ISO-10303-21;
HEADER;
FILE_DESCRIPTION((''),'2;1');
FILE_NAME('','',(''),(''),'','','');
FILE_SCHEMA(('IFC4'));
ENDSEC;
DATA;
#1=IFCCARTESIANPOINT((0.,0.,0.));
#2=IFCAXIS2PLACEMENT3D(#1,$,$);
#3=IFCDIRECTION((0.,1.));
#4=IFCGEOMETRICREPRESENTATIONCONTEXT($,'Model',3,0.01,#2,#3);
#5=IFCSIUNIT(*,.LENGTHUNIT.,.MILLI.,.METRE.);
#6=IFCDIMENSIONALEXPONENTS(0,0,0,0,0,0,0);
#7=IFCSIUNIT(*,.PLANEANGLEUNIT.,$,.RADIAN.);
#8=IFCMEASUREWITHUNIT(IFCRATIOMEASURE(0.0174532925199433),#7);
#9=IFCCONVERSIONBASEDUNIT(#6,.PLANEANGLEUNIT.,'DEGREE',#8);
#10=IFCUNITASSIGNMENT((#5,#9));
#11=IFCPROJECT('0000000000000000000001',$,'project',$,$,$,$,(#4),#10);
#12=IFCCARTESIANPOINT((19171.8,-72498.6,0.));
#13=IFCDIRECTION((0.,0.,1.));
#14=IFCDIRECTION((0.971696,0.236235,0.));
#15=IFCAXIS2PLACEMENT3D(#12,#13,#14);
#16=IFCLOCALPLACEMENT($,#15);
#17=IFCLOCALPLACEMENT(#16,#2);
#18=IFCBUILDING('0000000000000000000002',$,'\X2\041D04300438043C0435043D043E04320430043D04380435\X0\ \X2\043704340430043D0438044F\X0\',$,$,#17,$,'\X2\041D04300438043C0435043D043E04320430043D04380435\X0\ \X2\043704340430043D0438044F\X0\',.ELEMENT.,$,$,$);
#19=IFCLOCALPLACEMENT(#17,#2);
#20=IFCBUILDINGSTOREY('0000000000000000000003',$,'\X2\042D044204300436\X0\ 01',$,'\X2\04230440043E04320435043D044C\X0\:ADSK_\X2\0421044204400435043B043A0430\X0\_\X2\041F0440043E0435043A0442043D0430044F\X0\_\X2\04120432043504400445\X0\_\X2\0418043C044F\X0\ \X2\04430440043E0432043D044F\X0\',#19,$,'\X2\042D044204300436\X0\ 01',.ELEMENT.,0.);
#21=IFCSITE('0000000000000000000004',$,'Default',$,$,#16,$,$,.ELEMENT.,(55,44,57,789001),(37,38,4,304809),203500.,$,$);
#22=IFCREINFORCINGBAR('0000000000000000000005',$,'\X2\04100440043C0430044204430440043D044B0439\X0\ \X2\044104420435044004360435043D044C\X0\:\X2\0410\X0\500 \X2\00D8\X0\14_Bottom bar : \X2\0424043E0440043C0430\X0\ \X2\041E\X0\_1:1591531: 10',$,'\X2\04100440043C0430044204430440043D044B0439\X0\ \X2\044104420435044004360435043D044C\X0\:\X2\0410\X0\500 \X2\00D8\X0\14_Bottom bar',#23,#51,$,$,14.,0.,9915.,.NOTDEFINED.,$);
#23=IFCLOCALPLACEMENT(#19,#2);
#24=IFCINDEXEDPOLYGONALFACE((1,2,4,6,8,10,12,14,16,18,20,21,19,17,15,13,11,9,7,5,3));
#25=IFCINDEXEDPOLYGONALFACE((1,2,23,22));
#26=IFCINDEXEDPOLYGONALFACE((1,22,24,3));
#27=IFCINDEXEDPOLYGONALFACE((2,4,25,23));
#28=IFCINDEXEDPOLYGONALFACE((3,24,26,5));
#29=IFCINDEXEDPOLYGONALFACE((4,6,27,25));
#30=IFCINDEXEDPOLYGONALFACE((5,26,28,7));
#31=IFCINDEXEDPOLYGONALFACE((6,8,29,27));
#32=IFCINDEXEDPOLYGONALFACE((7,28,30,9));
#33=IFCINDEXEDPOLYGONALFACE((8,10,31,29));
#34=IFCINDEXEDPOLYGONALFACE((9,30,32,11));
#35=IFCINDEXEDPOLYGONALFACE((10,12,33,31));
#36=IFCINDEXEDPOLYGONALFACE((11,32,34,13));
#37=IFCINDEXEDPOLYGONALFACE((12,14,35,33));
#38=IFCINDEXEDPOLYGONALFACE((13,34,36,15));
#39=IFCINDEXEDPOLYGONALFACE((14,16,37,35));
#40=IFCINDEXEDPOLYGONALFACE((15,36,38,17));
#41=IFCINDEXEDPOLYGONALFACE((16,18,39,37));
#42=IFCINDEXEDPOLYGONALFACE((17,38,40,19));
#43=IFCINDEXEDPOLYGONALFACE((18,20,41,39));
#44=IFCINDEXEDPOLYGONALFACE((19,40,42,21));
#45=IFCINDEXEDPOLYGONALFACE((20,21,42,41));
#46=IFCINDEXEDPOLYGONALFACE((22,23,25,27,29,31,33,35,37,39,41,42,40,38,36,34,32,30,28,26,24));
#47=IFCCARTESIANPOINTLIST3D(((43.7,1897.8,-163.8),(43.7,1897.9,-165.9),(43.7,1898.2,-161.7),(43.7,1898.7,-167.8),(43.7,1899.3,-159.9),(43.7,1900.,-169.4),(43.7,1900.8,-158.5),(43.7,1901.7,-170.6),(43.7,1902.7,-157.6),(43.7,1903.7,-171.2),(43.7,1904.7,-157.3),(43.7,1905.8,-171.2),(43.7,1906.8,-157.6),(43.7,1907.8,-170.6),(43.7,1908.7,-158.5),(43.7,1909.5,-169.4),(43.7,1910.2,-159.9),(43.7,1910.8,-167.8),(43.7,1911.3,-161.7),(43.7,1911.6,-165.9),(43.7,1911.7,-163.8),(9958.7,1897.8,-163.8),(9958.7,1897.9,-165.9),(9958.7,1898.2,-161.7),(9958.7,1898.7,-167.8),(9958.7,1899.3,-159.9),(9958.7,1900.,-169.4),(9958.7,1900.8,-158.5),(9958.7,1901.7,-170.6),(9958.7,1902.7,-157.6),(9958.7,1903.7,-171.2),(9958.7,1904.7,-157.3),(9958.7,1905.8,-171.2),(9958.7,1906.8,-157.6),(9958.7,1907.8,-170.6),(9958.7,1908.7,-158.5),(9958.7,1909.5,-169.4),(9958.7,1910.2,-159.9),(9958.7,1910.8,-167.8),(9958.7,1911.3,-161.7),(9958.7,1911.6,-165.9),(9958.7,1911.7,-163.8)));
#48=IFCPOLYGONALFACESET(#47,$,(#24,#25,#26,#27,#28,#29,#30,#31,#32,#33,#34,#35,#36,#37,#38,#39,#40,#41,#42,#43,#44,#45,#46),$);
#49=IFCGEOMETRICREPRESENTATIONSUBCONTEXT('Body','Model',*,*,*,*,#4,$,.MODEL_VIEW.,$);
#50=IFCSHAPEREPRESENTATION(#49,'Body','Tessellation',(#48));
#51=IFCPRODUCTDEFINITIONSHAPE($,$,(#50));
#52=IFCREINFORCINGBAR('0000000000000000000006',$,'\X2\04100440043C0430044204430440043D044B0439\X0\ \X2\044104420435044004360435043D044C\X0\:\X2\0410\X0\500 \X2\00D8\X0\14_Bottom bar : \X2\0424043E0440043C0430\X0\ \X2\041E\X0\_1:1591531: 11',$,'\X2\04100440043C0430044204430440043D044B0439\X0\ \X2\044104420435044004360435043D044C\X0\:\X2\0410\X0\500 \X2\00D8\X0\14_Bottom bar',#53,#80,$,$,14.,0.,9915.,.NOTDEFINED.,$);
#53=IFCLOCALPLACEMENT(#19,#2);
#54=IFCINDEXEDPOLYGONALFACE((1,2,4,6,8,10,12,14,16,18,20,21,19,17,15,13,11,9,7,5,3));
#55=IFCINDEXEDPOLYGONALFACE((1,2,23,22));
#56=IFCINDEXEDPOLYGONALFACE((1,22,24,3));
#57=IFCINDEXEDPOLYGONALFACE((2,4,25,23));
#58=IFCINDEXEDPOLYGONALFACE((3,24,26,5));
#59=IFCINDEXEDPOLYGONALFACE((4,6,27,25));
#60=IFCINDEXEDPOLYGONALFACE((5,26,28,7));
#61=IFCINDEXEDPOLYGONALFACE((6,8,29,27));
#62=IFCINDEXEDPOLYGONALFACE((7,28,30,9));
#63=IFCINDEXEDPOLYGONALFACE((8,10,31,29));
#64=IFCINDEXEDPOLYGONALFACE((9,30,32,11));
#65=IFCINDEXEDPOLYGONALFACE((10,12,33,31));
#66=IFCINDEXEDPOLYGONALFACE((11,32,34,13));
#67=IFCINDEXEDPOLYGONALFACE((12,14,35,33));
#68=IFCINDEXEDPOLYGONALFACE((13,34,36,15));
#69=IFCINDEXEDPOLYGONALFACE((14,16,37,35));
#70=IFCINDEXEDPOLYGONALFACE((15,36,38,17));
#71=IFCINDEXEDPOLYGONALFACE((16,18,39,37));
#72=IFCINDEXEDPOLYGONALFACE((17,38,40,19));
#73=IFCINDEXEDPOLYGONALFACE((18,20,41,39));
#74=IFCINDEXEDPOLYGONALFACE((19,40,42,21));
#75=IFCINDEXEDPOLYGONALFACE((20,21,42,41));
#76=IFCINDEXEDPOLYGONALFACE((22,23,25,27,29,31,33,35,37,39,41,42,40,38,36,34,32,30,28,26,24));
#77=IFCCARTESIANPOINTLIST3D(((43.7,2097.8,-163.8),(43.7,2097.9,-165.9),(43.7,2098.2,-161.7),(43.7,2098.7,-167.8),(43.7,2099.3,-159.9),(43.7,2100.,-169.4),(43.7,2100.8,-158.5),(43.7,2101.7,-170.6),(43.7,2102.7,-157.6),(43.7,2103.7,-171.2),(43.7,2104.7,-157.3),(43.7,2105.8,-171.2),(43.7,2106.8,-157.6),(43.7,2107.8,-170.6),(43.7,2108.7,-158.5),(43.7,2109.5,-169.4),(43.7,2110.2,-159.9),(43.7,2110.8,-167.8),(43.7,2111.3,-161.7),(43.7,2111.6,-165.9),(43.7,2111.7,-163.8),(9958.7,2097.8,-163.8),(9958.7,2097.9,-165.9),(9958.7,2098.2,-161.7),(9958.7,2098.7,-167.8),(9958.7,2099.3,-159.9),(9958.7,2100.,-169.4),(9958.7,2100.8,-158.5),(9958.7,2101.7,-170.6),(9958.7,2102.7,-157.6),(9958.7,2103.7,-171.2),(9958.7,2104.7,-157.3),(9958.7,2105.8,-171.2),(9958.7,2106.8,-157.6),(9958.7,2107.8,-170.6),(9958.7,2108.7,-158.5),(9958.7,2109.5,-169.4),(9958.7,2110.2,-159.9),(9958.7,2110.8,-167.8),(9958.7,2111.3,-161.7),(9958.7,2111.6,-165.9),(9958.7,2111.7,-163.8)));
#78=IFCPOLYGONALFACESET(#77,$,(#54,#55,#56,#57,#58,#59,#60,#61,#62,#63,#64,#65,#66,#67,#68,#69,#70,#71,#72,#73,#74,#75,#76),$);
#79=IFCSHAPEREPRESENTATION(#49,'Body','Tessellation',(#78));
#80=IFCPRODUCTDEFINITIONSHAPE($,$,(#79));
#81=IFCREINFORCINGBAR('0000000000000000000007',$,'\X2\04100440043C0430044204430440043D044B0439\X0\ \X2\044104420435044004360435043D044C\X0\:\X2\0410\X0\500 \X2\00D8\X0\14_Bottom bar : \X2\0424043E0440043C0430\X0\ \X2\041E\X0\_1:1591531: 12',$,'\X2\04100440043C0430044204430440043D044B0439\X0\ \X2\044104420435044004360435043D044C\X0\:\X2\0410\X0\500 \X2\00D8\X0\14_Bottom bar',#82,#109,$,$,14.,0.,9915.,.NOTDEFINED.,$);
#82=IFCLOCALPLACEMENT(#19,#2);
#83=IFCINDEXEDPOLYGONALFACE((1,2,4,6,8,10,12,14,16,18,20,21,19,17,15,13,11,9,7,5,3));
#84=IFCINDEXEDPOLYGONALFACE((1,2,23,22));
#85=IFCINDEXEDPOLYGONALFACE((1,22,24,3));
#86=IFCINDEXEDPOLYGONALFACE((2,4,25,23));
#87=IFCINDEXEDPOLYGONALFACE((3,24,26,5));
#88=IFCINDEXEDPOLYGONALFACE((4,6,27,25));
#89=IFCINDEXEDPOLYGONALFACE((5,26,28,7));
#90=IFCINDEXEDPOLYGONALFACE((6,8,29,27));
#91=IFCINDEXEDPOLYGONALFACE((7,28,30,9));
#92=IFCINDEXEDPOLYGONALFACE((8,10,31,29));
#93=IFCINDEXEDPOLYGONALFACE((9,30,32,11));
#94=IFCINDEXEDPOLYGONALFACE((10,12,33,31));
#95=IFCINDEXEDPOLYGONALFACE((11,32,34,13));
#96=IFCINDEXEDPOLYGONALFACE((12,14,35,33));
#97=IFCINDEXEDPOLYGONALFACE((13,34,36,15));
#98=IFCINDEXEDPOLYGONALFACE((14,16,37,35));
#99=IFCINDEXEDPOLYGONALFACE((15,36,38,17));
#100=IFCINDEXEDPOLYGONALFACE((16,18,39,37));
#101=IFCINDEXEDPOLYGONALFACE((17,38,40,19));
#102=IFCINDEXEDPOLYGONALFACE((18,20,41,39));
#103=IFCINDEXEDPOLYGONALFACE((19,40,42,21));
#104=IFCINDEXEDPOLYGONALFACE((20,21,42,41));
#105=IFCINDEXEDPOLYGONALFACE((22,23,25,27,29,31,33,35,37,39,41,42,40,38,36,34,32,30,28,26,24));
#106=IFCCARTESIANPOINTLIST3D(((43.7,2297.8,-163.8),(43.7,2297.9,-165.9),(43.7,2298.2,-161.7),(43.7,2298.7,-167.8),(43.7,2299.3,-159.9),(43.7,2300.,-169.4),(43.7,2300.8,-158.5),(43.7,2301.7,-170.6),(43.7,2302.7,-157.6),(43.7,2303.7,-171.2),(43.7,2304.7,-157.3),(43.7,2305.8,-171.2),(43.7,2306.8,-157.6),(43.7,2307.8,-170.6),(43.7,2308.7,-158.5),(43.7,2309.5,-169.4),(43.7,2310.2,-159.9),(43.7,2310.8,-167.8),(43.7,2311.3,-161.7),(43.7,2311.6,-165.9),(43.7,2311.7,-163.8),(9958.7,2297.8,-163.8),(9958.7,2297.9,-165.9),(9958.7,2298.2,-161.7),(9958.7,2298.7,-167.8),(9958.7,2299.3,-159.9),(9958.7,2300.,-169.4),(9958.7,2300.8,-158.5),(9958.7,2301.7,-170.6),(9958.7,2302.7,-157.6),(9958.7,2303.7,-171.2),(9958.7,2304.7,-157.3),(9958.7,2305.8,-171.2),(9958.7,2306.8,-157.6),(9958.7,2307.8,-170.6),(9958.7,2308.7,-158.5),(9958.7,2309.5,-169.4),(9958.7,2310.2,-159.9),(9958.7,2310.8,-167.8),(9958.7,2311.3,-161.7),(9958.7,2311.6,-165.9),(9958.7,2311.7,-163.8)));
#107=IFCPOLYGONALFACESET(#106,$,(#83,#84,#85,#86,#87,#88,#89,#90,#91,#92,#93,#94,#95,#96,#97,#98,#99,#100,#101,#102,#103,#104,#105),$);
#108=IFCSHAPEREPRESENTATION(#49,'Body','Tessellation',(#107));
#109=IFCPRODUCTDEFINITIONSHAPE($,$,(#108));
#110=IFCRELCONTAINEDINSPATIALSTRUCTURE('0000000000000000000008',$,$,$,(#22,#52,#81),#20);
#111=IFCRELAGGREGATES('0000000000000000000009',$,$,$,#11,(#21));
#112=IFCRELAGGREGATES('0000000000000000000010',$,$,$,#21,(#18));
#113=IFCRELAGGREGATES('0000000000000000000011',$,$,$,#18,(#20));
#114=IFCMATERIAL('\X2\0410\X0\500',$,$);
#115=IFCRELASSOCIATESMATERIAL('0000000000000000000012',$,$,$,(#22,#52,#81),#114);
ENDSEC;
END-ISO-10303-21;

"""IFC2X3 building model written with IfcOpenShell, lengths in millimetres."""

from ifc_helpers import new_model, entity, si_unit, converted_unit, direction, frame, origin, place, context, subcontext, project, spatial, material, element, save


model = new_model("IFC2X3")

# Units and contexts
model_context = context("Model", 3, precision=0.01, world=origin(), true_north=direction((0.0, 1.0)))
body_context = subcontext(model_context, "Body", "Model", "MODEL_VIEW")
ifc_project = project(units=[si_unit("LENGTHUNIT", "METRE", prefix="MILLI"), converted_unit("PLANEANGLEUNIT", "DEGREE", entity("IfcRatioMeasure", 0.0174532925199433), si_unit("PLANEANGLEUNIT", "RADIAN"), dimensions=[0, 0, 0, 0, 0, 0, 0])], contexts=[model_context])

# Site, building, storey
site_placement = place(None, frame((19171.8, -72498.6, 0.0), z_axis=(0.0, 0.0, 1.0), x_axis=(0.971696, 0.236235, 0.0)))
site = spatial("IfcSite", under=ifc_project, at=site_placement, Name="Default", CompositionType="ELEMENT", RefLatitude=(55, 44, 57, 789001), RefLongitude=(37, 38, 4, 304809), RefElevation=203500.0)
building_placement = place(site_placement, origin())
building = spatial("IfcBuilding", under=site, at=building_placement, Name="Наименование здания", LongName="Наименование здания", CompositionType="ELEMENT")
storey_placement = place(building_placement, origin())
storey = spatial("IfcBuildingStorey", under=building, at=storey_placement, Name="Этаж 01", ObjectType="Уровень:ADSK_Стрелка_Проектная_Вверх_Имя уровня", LongName="Этаж 01", CompositionType="ELEMENT", Elevation=0.0)

# Reinforcing bars
ifc_material = material(Name="А500")
placement = place(storey_placement, origin())
element("IfcReinforcingBar", 1, at=placement, inside=storey, material=ifc_material, Name="Арматурный стержень:А500 Ø14_Bottom bar : Форма О_1:1591531: 10", ObjectType="Арматурный стержень:А500 Ø14_Bottom bar", BarLength=9915.0, BarRole="NOTDEFINED", CrossSectionArea=0.0, NominalDiameter=14.0, context=body_context, shape_type="AdvancedSweptSolid", body=[
    entity("IfcSweptDiskSolid", entity("IfcCompositeCurve", [entity("IfcCompositeCurveSegment", "CONTINUOUS", True, entity("IfcPolyline", [entity("IfcCartesianPoint", [43.7, 1904.7, -164.3]), entity("IfcCartesianPoint", [9958.7, 1904.7, -164.3])]))], False), 7.0, None, 0.0, 1.0),
])
element("IfcReinforcingBar", 2, at=placement, inside=storey, material=ifc_material, Name="Арматурный стержень:А500 Ø14_Bottom bar : Форма О_1:1591531: 11", ObjectType="Арматурный стержень:А500 Ø14_Bottom bar", BarLength=9915.0, BarRole="NOTDEFINED", CrossSectionArea=0.0, NominalDiameter=14.0, context=body_context, shape_type="AdvancedSweptSolid", body=[
    entity("IfcSweptDiskSolid", entity("IfcCompositeCurve", [entity("IfcCompositeCurveSegment", "CONTINUOUS", True, entity("IfcPolyline", [entity("IfcCartesianPoint", [43.7, 2104.7, -164.3]), entity("IfcCartesianPoint", [9958.7, 2104.7, -164.3])]))], False), 7.0, None, 0.0, 1.0),
])
element("IfcReinforcingBar", 3, at=placement, inside=storey, material=ifc_material, Name="Арматурный стержень:А500 Ø14_Bottom bar : Форма О_1:1591531: 12", ObjectType="Арматурный стержень:А500 Ø14_Bottom bar", BarLength=9915.0, BarRole="NOTDEFINED", CrossSectionArea=0.0, NominalDiameter=14.0, context=body_context, shape_type="AdvancedSweptSolid", body=[
    entity("IfcSweptDiskSolid", entity("IfcCompositeCurve", [entity("IfcCompositeCurveSegment", "CONTINUOUS", True, entity("IfcPolyline", [entity("IfcCartesianPoint", [43.7, 2304.7, -164.3]), entity("IfcCartesianPoint", [9958.7, 2304.7, -164.3])]))], False), 7.0, None, 0.0, 1.0),
])

save(model, "model.ifc")
